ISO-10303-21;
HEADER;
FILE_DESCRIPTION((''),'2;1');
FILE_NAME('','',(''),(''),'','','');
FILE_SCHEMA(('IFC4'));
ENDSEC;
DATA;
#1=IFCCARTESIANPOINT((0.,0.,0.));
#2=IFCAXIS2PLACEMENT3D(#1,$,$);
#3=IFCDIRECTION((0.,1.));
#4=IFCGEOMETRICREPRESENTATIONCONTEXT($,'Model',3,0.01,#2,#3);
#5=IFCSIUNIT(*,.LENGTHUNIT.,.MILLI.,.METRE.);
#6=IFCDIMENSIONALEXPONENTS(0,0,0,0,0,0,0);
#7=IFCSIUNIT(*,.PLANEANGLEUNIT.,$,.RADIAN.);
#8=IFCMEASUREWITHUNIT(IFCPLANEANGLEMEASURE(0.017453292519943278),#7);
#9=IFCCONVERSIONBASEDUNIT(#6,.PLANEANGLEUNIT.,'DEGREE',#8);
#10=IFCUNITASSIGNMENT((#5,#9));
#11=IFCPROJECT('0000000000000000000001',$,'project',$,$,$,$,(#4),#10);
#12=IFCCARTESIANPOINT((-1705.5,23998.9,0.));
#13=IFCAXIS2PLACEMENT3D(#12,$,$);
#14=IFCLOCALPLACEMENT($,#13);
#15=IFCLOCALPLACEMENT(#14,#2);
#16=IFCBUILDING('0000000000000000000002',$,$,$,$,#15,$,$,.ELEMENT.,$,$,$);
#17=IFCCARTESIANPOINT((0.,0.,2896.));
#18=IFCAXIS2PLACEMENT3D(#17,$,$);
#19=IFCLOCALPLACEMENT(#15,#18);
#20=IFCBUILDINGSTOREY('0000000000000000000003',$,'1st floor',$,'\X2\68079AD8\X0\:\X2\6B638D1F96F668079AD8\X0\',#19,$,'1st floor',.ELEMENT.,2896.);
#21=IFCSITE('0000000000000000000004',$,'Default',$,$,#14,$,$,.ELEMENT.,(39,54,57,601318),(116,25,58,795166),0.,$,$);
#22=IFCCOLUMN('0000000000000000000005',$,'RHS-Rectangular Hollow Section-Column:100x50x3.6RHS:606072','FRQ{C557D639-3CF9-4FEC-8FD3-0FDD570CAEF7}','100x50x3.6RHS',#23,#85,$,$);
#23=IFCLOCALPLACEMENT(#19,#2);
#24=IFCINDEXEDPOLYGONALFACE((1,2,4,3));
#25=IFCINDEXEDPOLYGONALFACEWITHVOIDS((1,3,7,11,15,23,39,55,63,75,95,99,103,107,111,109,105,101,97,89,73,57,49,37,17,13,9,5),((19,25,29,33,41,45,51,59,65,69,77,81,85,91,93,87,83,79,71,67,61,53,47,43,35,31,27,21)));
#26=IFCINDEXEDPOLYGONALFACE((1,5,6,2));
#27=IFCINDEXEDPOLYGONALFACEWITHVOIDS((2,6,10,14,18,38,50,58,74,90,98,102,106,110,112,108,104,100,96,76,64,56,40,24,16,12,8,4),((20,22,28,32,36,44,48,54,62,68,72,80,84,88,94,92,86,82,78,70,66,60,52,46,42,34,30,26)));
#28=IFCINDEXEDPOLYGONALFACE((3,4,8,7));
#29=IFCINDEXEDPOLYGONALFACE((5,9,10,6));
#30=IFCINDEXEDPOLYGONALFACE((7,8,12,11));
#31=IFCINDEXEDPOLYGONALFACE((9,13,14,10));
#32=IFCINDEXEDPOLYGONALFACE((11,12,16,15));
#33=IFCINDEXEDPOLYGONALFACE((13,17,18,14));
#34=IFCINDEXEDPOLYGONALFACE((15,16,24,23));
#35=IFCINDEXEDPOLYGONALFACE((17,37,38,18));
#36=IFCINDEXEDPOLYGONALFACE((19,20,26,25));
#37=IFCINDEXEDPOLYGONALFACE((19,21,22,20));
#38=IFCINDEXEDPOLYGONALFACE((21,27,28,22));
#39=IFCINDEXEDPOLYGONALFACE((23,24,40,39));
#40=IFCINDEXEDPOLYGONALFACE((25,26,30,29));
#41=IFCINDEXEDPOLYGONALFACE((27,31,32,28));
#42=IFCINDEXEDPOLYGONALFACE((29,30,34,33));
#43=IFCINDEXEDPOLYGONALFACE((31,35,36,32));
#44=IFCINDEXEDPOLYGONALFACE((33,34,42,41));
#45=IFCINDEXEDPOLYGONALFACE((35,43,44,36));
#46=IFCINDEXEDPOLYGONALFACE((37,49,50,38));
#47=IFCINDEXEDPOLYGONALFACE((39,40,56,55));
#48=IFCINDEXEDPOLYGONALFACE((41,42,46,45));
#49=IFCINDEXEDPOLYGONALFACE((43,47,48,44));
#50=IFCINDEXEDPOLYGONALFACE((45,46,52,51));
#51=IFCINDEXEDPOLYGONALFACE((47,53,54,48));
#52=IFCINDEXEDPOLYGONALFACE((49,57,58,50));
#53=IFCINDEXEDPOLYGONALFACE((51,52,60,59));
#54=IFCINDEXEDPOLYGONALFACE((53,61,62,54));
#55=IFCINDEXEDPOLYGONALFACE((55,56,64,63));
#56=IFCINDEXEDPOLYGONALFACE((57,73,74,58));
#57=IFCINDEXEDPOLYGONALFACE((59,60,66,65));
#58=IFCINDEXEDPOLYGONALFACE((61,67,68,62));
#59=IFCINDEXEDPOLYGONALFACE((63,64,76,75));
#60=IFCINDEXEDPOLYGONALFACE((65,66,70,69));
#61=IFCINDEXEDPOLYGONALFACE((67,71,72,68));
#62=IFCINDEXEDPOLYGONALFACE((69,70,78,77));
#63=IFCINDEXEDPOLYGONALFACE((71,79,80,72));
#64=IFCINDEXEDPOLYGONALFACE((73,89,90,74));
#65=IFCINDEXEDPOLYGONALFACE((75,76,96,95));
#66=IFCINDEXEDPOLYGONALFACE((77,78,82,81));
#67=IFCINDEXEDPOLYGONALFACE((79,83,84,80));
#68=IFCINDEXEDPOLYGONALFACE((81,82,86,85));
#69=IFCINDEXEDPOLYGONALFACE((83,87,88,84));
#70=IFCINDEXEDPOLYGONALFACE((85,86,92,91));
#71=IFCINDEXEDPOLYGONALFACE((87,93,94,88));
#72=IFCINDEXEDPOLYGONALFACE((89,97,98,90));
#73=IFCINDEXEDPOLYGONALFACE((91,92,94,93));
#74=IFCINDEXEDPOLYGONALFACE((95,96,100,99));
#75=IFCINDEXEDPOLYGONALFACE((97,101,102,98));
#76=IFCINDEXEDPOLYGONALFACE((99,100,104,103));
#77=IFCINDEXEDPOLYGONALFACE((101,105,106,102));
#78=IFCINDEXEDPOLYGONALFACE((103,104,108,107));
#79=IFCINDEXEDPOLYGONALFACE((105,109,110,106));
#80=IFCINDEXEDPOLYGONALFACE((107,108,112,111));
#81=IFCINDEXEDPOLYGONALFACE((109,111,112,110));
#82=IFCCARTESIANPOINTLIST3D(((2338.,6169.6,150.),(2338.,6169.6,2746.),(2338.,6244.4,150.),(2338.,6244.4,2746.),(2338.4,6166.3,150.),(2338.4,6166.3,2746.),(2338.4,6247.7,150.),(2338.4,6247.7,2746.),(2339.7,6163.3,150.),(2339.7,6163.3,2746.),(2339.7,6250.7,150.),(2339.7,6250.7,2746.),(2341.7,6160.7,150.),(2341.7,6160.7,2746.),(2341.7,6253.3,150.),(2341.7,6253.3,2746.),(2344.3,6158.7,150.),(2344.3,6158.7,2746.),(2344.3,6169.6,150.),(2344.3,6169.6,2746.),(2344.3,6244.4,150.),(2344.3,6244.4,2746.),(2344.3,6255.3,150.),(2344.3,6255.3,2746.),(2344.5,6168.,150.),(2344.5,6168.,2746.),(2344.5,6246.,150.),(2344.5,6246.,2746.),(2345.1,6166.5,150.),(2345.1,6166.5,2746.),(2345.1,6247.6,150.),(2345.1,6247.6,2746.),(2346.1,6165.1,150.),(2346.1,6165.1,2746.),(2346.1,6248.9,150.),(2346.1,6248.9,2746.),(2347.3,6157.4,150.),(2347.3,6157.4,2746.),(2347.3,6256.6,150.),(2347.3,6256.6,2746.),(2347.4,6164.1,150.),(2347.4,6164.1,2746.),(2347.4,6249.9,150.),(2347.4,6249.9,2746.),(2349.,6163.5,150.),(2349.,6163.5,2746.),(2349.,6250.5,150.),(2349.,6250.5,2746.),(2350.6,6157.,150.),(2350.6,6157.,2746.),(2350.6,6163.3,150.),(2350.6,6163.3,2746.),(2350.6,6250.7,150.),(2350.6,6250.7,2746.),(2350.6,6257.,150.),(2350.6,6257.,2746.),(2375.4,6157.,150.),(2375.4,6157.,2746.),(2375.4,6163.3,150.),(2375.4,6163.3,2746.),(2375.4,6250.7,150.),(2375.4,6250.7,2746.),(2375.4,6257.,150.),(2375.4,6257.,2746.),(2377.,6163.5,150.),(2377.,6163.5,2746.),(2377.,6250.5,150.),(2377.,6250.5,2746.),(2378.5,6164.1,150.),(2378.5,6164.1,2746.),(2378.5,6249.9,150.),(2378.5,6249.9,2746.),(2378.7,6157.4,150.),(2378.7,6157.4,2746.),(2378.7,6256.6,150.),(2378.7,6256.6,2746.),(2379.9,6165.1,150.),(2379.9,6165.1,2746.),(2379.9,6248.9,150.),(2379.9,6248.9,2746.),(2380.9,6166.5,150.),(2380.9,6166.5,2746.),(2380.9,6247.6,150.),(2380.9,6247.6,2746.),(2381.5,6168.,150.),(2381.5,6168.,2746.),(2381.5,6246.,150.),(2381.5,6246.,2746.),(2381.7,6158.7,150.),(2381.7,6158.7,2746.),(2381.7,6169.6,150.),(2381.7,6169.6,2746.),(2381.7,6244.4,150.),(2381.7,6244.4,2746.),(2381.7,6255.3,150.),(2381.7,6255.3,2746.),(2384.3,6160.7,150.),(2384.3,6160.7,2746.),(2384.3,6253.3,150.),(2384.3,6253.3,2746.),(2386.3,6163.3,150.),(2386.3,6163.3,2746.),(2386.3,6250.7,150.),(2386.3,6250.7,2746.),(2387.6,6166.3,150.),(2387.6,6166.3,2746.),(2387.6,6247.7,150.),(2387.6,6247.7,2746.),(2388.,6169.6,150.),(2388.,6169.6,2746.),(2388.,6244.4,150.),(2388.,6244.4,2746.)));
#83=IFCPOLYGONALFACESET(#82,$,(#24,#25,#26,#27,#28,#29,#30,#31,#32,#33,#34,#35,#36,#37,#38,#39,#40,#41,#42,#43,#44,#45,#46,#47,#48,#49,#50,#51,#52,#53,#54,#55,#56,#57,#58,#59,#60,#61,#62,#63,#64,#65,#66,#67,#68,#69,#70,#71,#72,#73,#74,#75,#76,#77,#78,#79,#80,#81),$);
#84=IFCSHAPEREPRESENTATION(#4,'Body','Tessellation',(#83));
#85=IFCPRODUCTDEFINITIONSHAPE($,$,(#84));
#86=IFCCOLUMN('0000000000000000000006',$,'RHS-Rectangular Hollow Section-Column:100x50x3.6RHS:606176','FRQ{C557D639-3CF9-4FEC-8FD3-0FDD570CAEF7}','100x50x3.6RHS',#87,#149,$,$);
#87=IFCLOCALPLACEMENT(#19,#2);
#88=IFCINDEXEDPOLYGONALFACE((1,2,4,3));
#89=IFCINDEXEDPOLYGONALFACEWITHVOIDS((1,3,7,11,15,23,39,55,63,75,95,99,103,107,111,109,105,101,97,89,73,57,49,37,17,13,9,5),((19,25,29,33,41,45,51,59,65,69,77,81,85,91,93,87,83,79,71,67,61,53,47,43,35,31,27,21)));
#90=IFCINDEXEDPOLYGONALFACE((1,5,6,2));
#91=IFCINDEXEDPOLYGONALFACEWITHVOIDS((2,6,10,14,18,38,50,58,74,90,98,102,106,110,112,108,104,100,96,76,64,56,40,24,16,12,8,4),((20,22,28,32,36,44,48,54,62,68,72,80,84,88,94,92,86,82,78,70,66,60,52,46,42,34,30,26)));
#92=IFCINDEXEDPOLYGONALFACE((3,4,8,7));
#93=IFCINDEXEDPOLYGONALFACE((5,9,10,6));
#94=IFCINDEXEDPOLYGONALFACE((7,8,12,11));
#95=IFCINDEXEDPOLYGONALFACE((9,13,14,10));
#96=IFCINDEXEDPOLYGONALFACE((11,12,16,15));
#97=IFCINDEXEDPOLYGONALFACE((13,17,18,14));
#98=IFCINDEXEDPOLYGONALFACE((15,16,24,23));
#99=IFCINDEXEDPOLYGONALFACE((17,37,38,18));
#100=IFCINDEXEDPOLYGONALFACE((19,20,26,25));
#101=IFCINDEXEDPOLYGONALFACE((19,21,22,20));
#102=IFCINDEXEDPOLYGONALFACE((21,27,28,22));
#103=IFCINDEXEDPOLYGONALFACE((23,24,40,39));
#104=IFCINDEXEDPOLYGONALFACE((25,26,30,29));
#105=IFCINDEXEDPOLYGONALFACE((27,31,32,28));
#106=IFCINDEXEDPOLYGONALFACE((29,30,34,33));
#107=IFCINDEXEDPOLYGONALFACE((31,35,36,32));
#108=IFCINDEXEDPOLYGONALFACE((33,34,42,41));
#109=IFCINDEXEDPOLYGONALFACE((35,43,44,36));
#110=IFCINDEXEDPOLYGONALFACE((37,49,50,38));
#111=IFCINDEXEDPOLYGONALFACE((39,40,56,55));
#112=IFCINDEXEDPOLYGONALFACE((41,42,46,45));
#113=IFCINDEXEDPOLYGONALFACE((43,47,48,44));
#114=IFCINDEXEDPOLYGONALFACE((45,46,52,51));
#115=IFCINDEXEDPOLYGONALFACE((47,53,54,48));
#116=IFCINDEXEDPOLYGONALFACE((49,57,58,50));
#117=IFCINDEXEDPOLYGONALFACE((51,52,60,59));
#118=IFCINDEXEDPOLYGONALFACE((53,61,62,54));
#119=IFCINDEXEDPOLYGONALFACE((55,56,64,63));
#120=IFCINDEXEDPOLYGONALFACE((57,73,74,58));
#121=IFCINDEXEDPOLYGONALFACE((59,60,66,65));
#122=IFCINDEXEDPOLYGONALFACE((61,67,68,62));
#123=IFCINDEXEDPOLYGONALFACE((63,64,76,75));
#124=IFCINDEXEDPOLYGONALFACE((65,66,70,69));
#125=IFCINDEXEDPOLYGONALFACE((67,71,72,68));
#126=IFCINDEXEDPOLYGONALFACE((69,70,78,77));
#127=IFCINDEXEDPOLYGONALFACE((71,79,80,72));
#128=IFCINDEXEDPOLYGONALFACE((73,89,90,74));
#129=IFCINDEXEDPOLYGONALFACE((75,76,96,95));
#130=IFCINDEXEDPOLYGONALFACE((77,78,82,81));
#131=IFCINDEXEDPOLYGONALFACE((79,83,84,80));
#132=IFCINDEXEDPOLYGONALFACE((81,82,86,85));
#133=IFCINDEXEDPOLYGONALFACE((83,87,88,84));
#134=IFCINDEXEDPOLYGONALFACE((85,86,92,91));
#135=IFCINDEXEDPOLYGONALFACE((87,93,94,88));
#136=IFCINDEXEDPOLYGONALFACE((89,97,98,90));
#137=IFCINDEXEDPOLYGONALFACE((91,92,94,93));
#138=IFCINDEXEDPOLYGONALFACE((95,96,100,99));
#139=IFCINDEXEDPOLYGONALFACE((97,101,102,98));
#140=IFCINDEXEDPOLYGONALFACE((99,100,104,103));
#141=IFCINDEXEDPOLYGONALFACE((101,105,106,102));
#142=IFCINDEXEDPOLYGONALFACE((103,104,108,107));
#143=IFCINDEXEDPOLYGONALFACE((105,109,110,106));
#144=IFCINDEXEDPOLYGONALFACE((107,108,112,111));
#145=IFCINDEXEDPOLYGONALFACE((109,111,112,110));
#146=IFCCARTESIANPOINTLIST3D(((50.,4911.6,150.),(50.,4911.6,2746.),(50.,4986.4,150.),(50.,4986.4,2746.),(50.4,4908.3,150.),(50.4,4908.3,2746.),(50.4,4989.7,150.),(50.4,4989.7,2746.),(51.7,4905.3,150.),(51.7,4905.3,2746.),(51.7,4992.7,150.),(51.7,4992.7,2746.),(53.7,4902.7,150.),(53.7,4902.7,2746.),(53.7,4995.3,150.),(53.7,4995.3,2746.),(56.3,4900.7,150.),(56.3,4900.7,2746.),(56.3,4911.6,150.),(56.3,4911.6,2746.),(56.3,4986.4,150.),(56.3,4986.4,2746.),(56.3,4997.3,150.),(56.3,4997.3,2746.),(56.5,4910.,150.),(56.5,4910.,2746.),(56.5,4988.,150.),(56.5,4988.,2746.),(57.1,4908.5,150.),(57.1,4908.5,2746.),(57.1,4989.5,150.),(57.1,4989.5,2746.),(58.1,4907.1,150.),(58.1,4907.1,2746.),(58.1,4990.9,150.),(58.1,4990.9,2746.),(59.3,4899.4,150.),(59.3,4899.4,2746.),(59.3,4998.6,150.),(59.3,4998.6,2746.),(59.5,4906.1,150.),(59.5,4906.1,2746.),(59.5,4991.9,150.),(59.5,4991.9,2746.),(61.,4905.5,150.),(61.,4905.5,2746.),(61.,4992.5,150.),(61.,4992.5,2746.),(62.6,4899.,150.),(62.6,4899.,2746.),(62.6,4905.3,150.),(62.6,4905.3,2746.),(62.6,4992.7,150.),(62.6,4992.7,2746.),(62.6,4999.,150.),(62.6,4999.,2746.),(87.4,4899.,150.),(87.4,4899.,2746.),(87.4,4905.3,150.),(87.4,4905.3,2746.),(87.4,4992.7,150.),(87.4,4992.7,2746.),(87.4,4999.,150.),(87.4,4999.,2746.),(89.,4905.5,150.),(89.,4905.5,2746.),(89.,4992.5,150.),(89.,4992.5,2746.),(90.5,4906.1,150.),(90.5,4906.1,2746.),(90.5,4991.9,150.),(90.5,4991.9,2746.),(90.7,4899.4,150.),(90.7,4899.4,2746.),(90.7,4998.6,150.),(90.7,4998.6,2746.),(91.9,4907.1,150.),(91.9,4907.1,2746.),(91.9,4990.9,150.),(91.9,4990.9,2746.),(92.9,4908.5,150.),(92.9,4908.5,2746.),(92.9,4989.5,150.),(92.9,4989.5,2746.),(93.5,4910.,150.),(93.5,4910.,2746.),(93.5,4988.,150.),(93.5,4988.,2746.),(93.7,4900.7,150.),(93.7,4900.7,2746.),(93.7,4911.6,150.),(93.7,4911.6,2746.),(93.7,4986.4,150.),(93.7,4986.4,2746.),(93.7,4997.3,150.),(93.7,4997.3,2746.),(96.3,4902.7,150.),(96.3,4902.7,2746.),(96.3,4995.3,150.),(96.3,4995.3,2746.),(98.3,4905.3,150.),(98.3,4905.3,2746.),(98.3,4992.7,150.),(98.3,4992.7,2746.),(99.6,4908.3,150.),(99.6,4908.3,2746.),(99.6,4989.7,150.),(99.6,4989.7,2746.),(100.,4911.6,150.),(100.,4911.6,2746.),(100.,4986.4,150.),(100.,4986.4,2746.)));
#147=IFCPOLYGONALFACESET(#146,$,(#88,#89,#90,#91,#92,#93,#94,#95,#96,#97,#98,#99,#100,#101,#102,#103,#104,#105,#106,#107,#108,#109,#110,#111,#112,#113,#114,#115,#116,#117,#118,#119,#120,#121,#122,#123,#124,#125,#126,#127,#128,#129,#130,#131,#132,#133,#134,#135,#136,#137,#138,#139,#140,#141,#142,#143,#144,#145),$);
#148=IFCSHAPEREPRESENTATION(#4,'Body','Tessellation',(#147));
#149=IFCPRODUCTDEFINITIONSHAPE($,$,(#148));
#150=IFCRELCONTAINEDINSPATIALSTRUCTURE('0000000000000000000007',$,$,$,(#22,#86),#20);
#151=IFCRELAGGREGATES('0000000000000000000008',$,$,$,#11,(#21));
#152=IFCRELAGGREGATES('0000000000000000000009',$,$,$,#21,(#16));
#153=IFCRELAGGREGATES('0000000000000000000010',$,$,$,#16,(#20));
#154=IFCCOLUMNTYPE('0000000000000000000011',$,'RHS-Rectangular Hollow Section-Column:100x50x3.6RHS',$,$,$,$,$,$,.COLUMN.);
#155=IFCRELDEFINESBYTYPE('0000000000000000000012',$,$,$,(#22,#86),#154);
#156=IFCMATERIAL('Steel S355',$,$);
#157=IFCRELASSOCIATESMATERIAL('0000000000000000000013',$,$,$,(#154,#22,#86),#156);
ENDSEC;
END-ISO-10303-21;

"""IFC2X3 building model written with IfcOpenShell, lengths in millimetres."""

from ifc_helpers import new_model, entity, si_unit, converted_unit, direction, frame, origin, origin_2d, place, context, project, spatial, hollow_rectangle, extrude, clip, halfspace, material, type_object, element, save


model = new_model("IFC2X3")

# Units and contexts
model_context = context("Model", 3, precision=0.01, world=origin(), true_north=direction((0.0, 1.0)))
ifc_project = project(units=[si_unit("LENGTHUNIT", "METRE", prefix="MILLI"), converted_unit("PLANEANGLEUNIT", "DEGREE", entity("IfcPlaneAngleMeasure", 0.017453292519943278), si_unit("PLANEANGLEUNIT", "RADIAN"), dimensions=[0, 0, 0, 0, 0, 0, 0])], contexts=[model_context])

# Site, building, storey
site_placement = place(None, frame((-1705.5, 23998.9, 0.0)))
site = spatial("IfcSite", under=ifc_project, at=site_placement, Name="Default", CompositionType="ELEMENT", RefLatitude=(39, 54, 57, 601318), RefLongitude=(116, 25, 58, 795166), RefElevation=0.0)
building_placement = place(site_placement, origin())
building = spatial("IfcBuilding", under=site, at=building_placement, CompositionType="ELEMENT")
storey_placement = place(building_placement, frame((0.0, 0.0, 2896.0)))
storey = spatial("IfcBuildingStorey", under=building, at=storey_placement, Name="1st floor", ObjectType="标高:正负零标高", LongName="1st floor", CompositionType="ELEMENT", Elevation=2896.0)

# Shared definitions
ifc_material_1 = material(Name="Steel S355")

# Columns
column_type_1 = type_object("IfcColumnType", Name="RHS-Rectangular Hollow Section-Column:100x50x3.6RHS", PredefinedType="COLUMN", material=ifc_material_1)
column_1_placement = place(storey_placement, frame((2363.0, 6207.0, 2746.0), z_axis=(0.0, 0.0, 1.0), x_axis=(-1.0, 0.0, 0.0)))
element("IfcColumn", 1, at=column_1_placement, inside=storey, type_object=column_type_1, material=ifc_material_1, Name="RHS-Rectangular Hollow Section-Column:100x50x3.6RHS:606072", Description="FRQ{C557D639-3CF9-4FEC-8FD3-0FDD570CAEF7}", ObjectType="100x50x3.6RHS", context=model_context, shape_type="Clipping", body=[
    clip(extrude(hollow_rectangle(XDim=50.0, YDim=100.0, WallThickness=6.3, InnerFilletRadius=6.3, OuterFilletRadius=12.6, at=origin_2d()), origin(), (0.0, 0.0, -1.0), 2651.9), halfspace(frame((2363.0, 6207.0, -2596.0), z_axis=(0.0, 0.0, 1.0), x_axis=(-1.0, 0.0, 0.0)), True)),
])
column_2_placement = place(storey_placement, frame((75.0, 4949.0, 2746.0), z_axis=(0.0, 0.0, 1.0), x_axis=(-1.0, 0.0, 0.0)))
element("IfcColumn", 2, at=column_2_placement, inside=storey, type_object=column_type_1, material=ifc_material_1, Name="RHS-Rectangular Hollow Section-Column:100x50x3.6RHS:606176", Description="FRQ{C557D639-3CF9-4FEC-8FD3-0FDD570CAEF7}", ObjectType="100x50x3.6RHS", context=model_context, shape_type="Clipping", body=[
    clip(extrude(hollow_rectangle(XDim=50.0, YDim=100.0, WallThickness=6.3, InnerFilletRadius=6.3, OuterFilletRadius=12.6, at=origin_2d()), origin(), (0.0, 0.0, -1.0), 2651.9), halfspace(frame((75.0, 4949.0, -2596.0), z_axis=(0.0, 0.0, 1.0), x_axis=(-1.0, 0.0, 0.0)), True)),
])

save(model, "model.ifc")
